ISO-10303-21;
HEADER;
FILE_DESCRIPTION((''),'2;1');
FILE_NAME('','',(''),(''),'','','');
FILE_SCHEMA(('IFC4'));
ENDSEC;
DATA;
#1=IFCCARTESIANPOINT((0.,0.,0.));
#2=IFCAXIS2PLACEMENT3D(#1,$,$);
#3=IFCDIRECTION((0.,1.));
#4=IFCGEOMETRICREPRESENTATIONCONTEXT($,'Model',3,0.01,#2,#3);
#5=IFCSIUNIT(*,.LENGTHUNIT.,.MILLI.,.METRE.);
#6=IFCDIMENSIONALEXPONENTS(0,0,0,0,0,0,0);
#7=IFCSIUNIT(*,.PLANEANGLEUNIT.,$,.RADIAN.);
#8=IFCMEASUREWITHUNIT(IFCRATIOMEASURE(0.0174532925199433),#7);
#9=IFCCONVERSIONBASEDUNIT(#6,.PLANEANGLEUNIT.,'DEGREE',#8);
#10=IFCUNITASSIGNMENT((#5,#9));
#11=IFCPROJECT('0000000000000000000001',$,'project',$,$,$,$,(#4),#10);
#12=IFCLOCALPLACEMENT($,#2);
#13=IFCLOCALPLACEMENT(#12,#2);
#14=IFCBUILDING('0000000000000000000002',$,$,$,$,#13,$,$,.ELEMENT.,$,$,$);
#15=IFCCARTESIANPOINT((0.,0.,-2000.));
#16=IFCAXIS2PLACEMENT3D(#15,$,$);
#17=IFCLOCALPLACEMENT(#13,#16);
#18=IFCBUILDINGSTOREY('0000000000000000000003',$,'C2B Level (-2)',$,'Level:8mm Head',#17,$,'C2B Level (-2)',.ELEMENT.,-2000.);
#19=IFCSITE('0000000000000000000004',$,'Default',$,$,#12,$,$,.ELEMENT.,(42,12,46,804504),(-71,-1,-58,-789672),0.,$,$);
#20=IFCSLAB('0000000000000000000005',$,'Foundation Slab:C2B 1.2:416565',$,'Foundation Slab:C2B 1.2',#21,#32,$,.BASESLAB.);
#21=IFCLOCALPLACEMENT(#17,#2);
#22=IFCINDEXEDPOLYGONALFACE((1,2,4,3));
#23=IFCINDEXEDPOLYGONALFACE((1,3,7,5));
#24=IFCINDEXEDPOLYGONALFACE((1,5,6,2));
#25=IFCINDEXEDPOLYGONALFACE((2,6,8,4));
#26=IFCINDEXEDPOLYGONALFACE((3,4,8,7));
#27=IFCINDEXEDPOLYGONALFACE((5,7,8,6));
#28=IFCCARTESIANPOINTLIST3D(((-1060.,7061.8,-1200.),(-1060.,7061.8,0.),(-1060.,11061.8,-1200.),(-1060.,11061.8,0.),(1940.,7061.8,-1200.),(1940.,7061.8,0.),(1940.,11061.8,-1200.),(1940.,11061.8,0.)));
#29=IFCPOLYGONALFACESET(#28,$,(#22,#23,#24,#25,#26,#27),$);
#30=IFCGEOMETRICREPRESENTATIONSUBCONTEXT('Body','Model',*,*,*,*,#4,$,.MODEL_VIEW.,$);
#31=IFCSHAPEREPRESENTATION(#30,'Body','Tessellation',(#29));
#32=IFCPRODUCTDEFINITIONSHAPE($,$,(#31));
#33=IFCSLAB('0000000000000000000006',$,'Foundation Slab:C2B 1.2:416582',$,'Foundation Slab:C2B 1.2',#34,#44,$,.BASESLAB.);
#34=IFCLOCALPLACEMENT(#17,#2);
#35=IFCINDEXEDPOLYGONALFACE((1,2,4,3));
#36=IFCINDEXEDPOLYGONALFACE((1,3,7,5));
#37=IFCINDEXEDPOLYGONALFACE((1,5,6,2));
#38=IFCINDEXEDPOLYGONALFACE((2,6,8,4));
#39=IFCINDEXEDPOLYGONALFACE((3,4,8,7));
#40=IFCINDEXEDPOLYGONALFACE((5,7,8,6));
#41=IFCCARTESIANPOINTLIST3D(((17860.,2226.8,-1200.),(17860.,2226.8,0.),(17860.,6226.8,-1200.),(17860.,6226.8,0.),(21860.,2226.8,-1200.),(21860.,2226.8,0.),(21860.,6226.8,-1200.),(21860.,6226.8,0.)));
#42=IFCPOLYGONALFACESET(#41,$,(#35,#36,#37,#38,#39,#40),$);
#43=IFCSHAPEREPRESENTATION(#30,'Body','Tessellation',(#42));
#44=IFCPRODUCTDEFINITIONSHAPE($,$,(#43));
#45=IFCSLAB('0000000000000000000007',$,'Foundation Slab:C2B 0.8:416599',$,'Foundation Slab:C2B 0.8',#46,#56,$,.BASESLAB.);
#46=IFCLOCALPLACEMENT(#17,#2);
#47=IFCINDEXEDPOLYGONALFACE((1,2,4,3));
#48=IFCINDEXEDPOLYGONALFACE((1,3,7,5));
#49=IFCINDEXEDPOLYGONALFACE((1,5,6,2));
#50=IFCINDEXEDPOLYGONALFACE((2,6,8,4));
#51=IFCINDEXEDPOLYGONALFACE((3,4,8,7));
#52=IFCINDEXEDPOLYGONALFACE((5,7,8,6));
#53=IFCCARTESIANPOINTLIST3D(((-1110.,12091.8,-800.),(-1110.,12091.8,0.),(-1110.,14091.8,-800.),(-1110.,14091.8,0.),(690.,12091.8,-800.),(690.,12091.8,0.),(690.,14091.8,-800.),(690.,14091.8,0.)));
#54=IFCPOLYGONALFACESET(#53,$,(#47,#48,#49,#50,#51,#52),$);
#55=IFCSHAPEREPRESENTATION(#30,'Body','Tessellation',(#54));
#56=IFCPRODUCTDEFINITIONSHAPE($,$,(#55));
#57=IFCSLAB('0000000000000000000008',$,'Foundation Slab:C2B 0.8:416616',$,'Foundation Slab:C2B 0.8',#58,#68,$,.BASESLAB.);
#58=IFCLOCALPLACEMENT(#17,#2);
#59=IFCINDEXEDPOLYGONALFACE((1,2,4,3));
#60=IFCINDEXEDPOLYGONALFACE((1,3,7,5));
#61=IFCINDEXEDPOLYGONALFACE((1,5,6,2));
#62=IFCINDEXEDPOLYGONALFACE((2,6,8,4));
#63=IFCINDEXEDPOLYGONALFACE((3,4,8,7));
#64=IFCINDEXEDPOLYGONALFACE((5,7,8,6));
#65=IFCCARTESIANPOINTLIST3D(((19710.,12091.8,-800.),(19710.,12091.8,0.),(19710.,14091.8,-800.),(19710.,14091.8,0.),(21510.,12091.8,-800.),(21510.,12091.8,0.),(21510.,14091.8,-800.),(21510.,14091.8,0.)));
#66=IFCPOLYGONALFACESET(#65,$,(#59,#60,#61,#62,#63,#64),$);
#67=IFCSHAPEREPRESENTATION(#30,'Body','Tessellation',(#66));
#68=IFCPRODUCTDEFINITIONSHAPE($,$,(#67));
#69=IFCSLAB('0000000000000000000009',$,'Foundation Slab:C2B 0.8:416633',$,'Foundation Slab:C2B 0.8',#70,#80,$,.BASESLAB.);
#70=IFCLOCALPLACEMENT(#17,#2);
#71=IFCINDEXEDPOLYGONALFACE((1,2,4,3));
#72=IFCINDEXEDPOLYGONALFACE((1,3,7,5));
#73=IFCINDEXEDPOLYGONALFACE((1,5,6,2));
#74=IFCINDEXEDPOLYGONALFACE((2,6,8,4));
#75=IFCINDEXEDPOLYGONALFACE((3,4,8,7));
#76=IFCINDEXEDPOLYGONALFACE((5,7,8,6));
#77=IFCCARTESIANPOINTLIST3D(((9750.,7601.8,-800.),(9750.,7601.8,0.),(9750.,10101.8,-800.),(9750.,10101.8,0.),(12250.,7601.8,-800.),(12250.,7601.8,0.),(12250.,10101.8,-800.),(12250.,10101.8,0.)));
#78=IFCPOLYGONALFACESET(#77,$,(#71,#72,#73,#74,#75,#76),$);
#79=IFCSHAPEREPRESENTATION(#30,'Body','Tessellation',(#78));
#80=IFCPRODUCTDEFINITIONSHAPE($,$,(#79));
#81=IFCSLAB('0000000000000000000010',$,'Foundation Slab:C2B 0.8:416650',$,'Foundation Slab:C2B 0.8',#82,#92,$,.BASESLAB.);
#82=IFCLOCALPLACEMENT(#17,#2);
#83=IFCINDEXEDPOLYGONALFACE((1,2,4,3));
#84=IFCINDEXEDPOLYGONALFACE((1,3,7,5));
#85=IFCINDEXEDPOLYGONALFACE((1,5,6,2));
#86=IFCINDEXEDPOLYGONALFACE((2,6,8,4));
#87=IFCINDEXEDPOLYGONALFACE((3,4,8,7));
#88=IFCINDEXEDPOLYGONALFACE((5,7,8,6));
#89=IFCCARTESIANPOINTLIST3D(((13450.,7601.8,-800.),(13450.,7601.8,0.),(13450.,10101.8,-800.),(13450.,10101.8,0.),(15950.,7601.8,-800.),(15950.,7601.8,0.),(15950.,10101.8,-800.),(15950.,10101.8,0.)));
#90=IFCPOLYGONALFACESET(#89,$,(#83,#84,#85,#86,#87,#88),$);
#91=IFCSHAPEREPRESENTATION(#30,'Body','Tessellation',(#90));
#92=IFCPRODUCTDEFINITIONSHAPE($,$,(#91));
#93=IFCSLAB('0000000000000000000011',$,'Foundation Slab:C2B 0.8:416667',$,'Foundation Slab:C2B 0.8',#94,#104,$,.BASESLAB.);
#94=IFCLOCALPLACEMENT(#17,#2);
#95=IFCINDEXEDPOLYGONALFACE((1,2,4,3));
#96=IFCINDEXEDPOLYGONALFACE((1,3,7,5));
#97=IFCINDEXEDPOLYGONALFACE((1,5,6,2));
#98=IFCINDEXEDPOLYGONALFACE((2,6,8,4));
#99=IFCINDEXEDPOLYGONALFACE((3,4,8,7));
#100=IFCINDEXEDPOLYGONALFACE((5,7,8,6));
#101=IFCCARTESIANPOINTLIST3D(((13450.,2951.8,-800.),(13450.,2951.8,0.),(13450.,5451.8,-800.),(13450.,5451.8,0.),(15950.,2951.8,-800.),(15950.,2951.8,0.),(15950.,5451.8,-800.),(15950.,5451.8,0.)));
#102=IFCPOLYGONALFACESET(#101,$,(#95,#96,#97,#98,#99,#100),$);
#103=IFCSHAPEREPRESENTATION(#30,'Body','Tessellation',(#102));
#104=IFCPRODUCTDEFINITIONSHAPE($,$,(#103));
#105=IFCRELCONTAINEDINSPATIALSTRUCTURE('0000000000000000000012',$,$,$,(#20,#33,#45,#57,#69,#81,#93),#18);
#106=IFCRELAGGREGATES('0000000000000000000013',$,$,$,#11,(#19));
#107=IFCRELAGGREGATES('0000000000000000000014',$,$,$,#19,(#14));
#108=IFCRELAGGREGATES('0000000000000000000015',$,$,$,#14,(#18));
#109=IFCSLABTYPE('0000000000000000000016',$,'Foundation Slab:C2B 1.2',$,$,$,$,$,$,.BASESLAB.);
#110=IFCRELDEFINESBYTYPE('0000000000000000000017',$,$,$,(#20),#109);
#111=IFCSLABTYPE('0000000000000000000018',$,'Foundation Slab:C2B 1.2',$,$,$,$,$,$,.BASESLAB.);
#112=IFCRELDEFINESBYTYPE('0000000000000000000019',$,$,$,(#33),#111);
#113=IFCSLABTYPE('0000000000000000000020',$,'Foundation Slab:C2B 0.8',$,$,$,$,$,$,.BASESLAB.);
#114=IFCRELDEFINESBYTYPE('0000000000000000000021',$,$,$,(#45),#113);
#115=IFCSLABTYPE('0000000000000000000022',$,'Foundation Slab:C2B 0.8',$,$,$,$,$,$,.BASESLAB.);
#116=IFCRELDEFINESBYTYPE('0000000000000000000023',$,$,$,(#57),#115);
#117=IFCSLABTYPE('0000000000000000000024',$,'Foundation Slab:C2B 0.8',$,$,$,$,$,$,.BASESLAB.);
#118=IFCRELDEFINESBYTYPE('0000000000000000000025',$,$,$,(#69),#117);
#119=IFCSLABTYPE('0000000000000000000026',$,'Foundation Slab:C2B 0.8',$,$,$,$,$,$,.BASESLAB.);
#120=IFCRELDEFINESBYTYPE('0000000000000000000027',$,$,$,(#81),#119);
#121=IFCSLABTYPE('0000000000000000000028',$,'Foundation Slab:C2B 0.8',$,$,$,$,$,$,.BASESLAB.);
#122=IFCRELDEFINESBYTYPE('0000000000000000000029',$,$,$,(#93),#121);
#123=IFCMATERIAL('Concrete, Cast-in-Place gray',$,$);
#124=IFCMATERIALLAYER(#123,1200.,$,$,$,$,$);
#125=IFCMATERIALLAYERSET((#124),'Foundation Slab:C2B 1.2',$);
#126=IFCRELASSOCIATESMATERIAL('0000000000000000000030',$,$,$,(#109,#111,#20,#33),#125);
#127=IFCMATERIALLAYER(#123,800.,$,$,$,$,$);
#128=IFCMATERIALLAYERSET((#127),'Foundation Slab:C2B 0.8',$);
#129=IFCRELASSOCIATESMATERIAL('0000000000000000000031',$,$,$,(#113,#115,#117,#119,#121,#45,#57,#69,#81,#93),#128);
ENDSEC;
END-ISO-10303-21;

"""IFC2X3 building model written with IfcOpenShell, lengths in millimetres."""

from ifc_helpers import new_model, entity, si_unit, converted_unit, direction, frame, frame_2d, origin, origin_2d_with_axis, place, context, subcontext, project, spatial, rectangle, extrude, material, layer, layer_set, layer_usage, type_object, element, save


model = new_model("IFC2X3")

# Units and contexts
model_context = context("Model", 3, precision=0.01, world=origin(), true_north=direction((0.0, 1.0)))
body_context = subcontext(model_context, "Body", "Model", "MODEL_VIEW")
ifc_project = project(units=[si_unit("LENGTHUNIT", "METRE", prefix="MILLI"), converted_unit("PLANEANGLEUNIT", "DEGREE", entity("IfcRatioMeasure", 0.0174532925199433), si_unit("PLANEANGLEUNIT", "RADIAN"), dimensions=[0, 0, 0, 0, 0, 0, 0])], contexts=[model_context])

# Site, building, storey
site_placement = place(None, origin())
site = spatial("IfcSite", under=ifc_project, at=site_placement, Name="Default", CompositionType="ELEMENT", RefLatitude=(42, 12, 46, 804504), RefLongitude=(-71, -1, -58, -789672), RefElevation=0.0)
building_placement = place(site_placement, origin())
building = spatial("IfcBuilding", under=site, at=building_placement, CompositionType="ELEMENT")
storey_placement = place(building_placement, frame((0.0, 0.0, -2000.0)))
storey = spatial("IfcBuildingStorey", under=building, at=storey_placement, Name="C2B Level (-2)", ObjectType="Level:8mm Head", LongName="C2B Level (-2)", CompositionType="ELEMENT", Elevation=-2000.0)

# Shared definitions
ifc_material = material(Name="Concrete, Cast-in-Place gray")

# Slabs
ifc_layer_1 = layer(ifc_material, 800.0)
ifc_layer_set_1 = layer_set([ifc_layer_1], Name="Foundation Slab:C2B 0.8")
ifc_layer_2 = layer(ifc_material, 1200.0)
ifc_layer_set_2 = layer_set([ifc_layer_2], Name="Foundation Slab:C2B 1.2")
ifc_layer_usage_1 = layer_usage(ifc_layer_set_2, "AXIS3", "POSITIVE", 0.0)
slab_type_1 = type_object("IfcSlabType", Name="Foundation Slab:C2B 1.2", PredefinedType="BASESLAB", material=ifc_layer_set_2)
slab_1_placement = place(storey_placement, origin())
element("IfcSlab", 1, at=slab_1_placement, inside=storey, type_object=slab_type_1, material=ifc_layer_usage_1, Name="Foundation Slab:C2B 1.2:416565", ObjectType="Foundation Slab:C2B 1.2", PredefinedType="BASESLAB", context=body_context, shape_type="SweptSolid", body=[
    extrude(rectangle(XDim=4000.0, YDim=3000.0, at=origin_2d_with_axis()), frame((440.0, 9061.8, 0.0), z_axis=(0.0, 0.0, -1.0), x_axis=(0.0, 1.0, 0.0)), (0.0, 0.0, 1.0), 1200.0),
])
ifc_layer_usage_2 = layer_usage(ifc_layer_set_2, "AXIS3", "POSITIVE", 0.0)
slab_type_2 = type_object("IfcSlabType", Name="Foundation Slab:C2B 1.2", PredefinedType="BASESLAB", material=ifc_layer_set_2)
slab_2_placement = place(storey_placement, origin())
element("IfcSlab", 2, at=slab_2_placement, inside=storey, type_object=slab_type_2, material=ifc_layer_usage_2, Name="Foundation Slab:C2B 1.2:416582", ObjectType="Foundation Slab:C2B 1.2", PredefinedType="BASESLAB", context=body_context, shape_type="SweptSolid", body=[
    extrude(rectangle(XDim=4000.0, YDim=4000.0, at=origin_2d_with_axis()), frame((19860.0, 4226.8, 0.0), z_axis=(0.0, 0.0, -1.0), x_axis=(0.0, 1.0, 0.0)), (0.0, 0.0, 1.0), 1200.0),
])
ifc_layer_usage_3 = layer_usage(ifc_layer_set_1, "AXIS3", "POSITIVE", 0.0)
slab_type_3 = type_object("IfcSlabType", Name="Foundation Slab:C2B 0.8", PredefinedType="BASESLAB", material=ifc_layer_set_1)
slab_3_placement = place(storey_placement, origin())
element("IfcSlab", 3, at=slab_3_placement, inside=storey, type_object=slab_type_3, material=ifc_layer_usage_3, Name="Foundation Slab:C2B 0.8:416599", ObjectType="Foundation Slab:C2B 0.8", PredefinedType="BASESLAB", context=body_context, shape_type="SweptSolid", body=[
    extrude(rectangle(XDim=2000.0, YDim=1800.0, at=origin_2d_with_axis()), frame((-210.0, 13091.8, 0.0), z_axis=(0.0, 0.0, -1.0), x_axis=(0.0, 1.0, 0.0)), (0.0, 0.0, 1.0), 800.0),
])
ifc_layer_usage_4 = layer_usage(ifc_layer_set_1, "AXIS3", "POSITIVE", 0.0)
slab_type_4 = type_object("IfcSlabType", Name="Foundation Slab:C2B 0.8", PredefinedType="BASESLAB", material=ifc_layer_set_1)
slab_4_placement = place(storey_placement, origin())
element("IfcSlab", 4, at=slab_4_placement, inside=storey, type_object=slab_type_4, material=ifc_layer_usage_4, Name="Foundation Slab:C2B 0.8:416616", ObjectType="Foundation Slab:C2B 0.8", PredefinedType="BASESLAB", context=body_context, shape_type="SweptSolid", body=[
    extrude(rectangle(XDim=2000.0, YDim=1800.0, at=origin_2d_with_axis()), frame((20610.0, 13091.8, 0.0), z_axis=(0.0, 0.0, -1.0), x_axis=(0.0, 1.0, 0.0)), (0.0, 0.0, 1.0), 800.0),
])
ifc_layer_usage_5 = layer_usage(ifc_layer_set_1, "AXIS3", "POSITIVE", 0.0)
slab_type_5 = type_object("IfcSlabType", Name="Foundation Slab:C2B 0.8", PredefinedType="BASESLAB", material=ifc_layer_set_1)
slab_5_placement = place(storey_placement, origin())
element("IfcSlab", 5, at=slab_5_placement, inside=storey, type_object=slab_type_5, material=ifc_layer_usage_5, Name="Foundation Slab:C2B 0.8:416633", ObjectType="Foundation Slab:C2B 0.8", PredefinedType="BASESLAB", context=body_context, shape_type="SweptSolid", body=[
    extrude(rectangle(XDim=2500.0, YDim=2500.0, at=origin_2d_with_axis()), frame((11000.0, 8851.8, 0.0), z_axis=(0.0, 0.0, -1.0), x_axis=(0.0, 1.0, 0.0)), (0.0, 0.0, 1.0), 800.0),
])
ifc_layer_usage_6 = layer_usage(ifc_layer_set_1, "AXIS3", "POSITIVE", 0.0)
slab_type_6 = type_object("IfcSlabType", Name="Foundation Slab:C2B 0.8", PredefinedType="BASESLAB", material=ifc_layer_set_1)
slab_6_placement = place(storey_placement, origin())
element("IfcSlab", 6, at=slab_6_placement, inside=storey, type_object=slab_type_6, material=ifc_layer_usage_6, Name="Foundation Slab:C2B 0.8:416650", ObjectType="Foundation Slab:C2B 0.8", PredefinedType="BASESLAB", context=body_context, shape_type="SweptSolid", body=[
    extrude(rectangle(XDim=2500.0, YDim=2500.0, at=origin_2d_with_axis()), frame((14700.0, 8851.8, 0.0), z_axis=(0.0, 0.0, -1.0), x_axis=(0.0, 1.0, 0.0)), (0.0, 0.0, 1.0), 800.0),
])
ifc_layer_usage_7 = layer_usage(ifc_layer_set_1, "AXIS3", "POSITIVE", 0.0)
slab_type_7 = type_object("IfcSlabType", Name="Foundation Slab:C2B 0.8", PredefinedType="BASESLAB", material=ifc_layer_set_1)
slab_7_placement = place(storey_placement, origin())
element("IfcSlab", 7, at=slab_7_placement, inside=storey, type_object=slab_type_7, material=ifc_layer_usage_7, Name="Foundation Slab:C2B 0.8:416667", ObjectType="Foundation Slab:C2B 0.8", PredefinedType="BASESLAB", context=body_context, shape_type="SweptSolid", body=[
    extrude(rectangle(XDim=2500.0, YDim=2500.0, at=frame_2d((0.0, 0.0), x_axis=(1.0, 0.0))), frame((14700.0, 4201.8, 0.0), z_axis=(0.0, 0.0, -1.0), x_axis=(0.0, 1.0, 0.0)), (0.0, 0.0, 1.0), 800.0),
])

save(model, "model.ifc")
